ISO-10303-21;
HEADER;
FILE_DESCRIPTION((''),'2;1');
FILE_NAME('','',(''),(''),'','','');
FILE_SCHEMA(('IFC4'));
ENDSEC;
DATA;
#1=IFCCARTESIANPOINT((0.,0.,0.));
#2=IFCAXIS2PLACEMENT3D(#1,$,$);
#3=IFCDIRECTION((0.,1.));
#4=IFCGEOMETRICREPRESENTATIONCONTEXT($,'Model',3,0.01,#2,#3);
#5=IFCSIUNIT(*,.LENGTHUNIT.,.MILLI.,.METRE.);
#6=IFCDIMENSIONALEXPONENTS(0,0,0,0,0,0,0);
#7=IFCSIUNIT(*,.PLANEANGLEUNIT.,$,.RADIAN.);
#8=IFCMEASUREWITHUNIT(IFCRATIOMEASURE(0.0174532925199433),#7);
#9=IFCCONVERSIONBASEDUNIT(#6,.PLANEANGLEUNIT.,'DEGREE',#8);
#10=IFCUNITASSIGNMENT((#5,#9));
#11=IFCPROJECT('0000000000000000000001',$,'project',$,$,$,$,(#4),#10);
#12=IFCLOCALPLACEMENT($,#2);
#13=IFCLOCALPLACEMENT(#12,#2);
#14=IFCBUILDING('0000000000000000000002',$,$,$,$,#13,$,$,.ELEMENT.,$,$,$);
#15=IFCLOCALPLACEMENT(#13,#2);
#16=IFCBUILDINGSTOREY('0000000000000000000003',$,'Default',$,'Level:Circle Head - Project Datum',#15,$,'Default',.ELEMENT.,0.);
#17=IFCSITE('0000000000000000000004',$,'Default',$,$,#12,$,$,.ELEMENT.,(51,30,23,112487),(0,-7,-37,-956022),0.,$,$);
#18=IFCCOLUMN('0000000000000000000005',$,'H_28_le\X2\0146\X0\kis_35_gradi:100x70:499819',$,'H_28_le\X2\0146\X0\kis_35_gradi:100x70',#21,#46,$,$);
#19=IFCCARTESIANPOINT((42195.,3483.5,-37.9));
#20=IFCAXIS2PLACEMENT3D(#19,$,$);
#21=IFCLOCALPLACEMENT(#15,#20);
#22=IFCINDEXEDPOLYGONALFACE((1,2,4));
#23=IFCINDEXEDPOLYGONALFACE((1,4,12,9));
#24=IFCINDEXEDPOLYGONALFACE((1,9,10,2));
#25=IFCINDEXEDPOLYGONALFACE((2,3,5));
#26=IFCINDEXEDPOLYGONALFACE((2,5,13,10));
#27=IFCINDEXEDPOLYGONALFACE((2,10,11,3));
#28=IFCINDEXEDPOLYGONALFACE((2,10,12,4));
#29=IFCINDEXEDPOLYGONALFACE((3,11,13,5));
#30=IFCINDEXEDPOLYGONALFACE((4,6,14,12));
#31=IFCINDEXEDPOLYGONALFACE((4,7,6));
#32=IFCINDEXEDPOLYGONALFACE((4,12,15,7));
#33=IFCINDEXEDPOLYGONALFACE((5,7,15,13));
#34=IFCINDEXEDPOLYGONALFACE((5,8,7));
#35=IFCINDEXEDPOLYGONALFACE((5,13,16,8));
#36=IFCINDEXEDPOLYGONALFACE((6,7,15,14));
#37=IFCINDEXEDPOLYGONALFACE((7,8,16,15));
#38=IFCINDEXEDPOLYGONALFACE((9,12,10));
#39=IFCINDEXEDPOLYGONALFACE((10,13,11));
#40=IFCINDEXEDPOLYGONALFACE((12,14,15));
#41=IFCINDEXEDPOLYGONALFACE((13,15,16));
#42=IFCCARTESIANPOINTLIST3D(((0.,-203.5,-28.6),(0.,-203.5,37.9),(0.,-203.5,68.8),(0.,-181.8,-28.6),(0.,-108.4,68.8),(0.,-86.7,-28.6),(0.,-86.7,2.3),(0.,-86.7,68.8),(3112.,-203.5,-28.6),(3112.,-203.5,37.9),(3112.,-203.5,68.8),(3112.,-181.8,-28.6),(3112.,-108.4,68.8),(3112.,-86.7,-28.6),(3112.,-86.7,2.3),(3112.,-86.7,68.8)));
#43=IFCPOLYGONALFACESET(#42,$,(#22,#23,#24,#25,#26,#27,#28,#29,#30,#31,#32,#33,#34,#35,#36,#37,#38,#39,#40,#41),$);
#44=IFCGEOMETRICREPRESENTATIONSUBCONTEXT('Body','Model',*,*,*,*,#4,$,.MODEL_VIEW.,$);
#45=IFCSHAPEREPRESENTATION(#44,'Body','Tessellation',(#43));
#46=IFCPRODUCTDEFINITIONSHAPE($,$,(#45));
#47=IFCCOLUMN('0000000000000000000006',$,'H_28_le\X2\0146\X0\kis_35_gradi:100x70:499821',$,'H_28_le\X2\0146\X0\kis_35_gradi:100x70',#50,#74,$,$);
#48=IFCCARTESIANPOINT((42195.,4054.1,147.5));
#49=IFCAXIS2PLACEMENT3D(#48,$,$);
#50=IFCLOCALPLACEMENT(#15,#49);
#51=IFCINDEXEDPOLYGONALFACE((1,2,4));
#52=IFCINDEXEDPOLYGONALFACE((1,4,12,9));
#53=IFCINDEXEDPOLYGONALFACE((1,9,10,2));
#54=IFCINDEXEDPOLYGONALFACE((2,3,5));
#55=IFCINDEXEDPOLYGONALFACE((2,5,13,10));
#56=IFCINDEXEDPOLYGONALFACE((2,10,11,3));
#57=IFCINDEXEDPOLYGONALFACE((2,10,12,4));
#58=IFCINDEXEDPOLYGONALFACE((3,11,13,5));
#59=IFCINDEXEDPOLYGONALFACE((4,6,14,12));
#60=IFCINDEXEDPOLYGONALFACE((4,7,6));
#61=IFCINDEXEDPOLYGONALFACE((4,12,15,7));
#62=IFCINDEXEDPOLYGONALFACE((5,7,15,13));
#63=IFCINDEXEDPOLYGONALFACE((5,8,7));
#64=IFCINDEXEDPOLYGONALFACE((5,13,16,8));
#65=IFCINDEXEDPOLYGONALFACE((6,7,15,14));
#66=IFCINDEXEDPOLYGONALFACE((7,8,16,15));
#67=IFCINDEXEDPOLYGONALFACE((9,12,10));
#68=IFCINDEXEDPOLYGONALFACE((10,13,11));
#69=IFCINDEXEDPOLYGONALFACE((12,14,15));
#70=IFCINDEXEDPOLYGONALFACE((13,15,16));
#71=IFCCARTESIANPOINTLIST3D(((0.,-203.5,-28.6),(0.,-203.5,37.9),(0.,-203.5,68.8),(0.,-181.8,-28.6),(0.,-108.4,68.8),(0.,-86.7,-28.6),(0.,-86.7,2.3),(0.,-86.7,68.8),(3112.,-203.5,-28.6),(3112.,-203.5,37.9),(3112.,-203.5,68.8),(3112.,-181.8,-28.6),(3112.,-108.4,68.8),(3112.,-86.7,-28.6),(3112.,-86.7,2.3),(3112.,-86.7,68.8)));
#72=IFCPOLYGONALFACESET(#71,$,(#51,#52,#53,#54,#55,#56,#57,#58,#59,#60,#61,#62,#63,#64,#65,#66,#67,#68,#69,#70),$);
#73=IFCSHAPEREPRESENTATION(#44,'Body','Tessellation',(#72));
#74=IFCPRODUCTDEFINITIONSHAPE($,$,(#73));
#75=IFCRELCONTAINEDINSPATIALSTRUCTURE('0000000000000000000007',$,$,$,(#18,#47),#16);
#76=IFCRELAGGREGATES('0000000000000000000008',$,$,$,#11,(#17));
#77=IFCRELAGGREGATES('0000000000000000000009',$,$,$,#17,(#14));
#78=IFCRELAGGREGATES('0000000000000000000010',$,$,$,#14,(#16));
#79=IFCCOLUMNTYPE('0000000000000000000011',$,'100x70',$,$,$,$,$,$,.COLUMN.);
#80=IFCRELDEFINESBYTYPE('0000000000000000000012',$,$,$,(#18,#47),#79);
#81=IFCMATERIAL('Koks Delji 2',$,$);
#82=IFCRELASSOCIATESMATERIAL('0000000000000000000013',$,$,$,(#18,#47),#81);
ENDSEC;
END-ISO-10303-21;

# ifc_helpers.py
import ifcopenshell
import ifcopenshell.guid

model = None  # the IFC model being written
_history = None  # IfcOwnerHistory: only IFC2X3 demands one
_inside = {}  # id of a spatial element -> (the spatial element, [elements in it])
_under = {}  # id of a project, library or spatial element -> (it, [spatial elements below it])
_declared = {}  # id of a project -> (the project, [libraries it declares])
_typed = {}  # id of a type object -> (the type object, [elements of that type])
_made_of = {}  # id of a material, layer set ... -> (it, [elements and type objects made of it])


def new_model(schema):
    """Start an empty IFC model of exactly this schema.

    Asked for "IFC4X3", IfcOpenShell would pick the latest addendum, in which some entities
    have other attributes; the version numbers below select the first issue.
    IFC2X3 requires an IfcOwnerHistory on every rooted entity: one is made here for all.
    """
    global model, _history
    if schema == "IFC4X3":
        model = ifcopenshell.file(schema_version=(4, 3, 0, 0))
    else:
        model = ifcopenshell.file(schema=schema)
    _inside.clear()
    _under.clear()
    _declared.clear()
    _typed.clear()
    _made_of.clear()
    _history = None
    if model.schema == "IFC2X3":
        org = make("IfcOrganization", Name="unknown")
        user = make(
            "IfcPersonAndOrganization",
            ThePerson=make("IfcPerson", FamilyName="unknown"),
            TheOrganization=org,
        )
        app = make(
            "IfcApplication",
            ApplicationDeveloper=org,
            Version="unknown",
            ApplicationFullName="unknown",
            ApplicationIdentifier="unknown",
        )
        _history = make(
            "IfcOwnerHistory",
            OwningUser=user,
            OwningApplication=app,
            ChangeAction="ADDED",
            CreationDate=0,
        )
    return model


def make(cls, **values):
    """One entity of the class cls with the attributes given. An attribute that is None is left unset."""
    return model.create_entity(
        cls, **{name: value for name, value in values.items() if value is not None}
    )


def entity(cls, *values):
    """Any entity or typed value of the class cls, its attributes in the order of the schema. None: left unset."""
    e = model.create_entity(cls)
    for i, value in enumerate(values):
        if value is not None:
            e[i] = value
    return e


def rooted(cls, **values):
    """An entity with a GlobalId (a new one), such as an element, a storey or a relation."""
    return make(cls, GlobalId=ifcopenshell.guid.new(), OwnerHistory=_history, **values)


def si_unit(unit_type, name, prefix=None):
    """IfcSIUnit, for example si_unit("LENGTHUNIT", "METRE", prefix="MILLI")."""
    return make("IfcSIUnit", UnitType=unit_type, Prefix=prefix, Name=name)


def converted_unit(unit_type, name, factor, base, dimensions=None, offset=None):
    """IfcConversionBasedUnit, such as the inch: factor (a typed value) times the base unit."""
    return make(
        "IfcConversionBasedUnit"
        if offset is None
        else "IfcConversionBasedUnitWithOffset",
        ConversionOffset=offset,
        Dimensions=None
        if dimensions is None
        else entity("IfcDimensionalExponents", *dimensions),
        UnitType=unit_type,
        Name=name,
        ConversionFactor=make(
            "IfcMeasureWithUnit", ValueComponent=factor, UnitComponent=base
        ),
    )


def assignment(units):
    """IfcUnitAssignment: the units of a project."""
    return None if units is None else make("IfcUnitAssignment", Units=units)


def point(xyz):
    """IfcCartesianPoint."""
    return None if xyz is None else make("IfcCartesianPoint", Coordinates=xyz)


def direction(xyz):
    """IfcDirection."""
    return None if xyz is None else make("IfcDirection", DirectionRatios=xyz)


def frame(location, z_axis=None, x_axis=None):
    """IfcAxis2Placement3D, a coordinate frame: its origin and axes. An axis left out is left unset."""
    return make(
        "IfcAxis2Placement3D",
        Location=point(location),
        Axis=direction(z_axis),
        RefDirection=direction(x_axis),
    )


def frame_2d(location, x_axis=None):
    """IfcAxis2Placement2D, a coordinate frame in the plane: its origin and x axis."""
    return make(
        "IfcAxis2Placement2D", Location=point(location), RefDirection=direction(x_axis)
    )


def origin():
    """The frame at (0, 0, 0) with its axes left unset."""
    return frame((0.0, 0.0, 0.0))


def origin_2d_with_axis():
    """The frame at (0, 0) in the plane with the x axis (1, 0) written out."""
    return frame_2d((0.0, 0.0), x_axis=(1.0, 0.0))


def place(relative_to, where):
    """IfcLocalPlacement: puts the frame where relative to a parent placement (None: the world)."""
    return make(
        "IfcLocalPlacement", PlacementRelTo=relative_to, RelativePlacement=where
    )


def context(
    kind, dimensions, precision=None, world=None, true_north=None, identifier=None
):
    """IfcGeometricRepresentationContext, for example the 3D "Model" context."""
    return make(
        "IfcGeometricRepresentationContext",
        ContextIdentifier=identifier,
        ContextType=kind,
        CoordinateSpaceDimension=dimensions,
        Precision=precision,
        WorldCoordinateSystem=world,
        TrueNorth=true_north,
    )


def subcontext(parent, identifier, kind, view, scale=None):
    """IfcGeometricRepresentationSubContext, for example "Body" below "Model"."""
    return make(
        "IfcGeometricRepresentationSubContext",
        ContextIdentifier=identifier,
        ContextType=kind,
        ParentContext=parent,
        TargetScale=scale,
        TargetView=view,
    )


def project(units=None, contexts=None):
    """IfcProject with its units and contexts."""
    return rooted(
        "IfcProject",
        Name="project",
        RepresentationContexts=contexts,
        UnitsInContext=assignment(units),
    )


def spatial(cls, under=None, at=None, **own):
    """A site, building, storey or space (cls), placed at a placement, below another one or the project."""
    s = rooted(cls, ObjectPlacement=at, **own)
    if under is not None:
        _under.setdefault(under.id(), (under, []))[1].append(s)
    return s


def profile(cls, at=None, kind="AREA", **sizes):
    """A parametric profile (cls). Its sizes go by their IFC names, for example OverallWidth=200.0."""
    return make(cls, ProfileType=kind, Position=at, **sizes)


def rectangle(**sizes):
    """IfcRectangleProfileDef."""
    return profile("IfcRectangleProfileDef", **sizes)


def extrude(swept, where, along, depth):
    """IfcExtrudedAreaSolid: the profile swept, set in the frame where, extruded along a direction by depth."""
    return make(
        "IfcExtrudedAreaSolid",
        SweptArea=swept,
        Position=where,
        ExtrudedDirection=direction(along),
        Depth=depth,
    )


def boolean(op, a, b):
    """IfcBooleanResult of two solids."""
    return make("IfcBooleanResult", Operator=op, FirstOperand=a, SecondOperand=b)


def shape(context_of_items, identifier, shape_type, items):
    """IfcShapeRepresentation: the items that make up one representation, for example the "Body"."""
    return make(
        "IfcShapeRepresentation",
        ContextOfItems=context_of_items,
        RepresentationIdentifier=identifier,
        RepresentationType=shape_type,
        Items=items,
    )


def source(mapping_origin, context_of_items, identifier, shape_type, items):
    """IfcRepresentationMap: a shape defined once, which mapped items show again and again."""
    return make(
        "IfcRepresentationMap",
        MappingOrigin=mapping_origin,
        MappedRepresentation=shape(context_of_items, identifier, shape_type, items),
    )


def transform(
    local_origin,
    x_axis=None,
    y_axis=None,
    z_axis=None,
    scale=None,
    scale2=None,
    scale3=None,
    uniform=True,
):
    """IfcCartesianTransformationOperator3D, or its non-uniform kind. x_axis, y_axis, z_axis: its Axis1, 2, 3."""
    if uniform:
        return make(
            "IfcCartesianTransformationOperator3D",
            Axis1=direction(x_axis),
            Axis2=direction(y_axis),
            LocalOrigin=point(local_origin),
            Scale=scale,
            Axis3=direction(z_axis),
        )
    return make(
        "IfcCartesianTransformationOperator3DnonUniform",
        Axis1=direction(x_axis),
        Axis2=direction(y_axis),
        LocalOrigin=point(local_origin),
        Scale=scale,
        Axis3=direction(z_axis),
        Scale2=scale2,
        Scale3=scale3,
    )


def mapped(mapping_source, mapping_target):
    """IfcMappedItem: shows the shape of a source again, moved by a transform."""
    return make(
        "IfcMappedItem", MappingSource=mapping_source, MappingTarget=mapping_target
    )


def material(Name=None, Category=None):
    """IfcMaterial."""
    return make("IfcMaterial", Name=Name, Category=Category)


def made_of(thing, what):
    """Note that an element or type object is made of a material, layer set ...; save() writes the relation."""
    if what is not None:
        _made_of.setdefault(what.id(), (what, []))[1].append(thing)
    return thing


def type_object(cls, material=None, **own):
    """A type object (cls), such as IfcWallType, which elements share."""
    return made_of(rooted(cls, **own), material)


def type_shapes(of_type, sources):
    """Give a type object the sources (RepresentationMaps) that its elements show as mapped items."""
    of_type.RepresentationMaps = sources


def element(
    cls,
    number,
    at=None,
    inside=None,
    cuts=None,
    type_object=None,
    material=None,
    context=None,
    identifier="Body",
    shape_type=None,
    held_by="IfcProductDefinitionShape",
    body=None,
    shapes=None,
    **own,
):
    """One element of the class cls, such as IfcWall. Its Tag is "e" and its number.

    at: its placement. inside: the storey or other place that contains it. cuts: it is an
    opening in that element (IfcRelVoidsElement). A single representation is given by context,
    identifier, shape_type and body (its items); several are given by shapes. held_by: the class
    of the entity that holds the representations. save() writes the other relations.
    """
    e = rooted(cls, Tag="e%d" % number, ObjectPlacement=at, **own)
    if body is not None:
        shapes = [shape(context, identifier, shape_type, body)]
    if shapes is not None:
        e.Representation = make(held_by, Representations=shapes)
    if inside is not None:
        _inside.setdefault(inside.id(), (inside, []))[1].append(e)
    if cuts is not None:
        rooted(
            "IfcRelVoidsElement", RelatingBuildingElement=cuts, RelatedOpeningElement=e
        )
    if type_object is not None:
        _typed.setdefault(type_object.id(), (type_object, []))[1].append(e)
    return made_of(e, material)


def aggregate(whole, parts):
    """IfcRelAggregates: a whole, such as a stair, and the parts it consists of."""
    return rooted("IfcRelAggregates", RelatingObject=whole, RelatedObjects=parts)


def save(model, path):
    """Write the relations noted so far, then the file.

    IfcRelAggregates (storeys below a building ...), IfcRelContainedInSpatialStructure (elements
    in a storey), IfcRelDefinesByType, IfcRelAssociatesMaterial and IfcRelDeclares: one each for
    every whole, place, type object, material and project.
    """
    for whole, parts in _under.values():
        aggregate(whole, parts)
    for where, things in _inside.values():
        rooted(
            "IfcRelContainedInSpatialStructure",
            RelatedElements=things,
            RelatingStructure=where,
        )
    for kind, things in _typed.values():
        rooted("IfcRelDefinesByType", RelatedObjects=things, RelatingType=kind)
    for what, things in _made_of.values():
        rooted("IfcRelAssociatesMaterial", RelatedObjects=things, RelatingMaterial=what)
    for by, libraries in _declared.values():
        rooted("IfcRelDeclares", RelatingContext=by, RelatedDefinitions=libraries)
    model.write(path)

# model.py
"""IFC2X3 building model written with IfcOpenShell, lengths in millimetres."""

from ifc_helpers import new_model, entity, si_unit, converted_unit, direction, frame, frame_2d, origin, origin_2d_with_axis, place, context, subcontext, project, spatial, rectangle, extrude, boolean, source, transform, mapped, material, type_object, type_shapes, element, save


model = new_model("IFC2X3")

# Units and contexts
model_context = context("Model", 3, precision=0.01, world=origin(), true_north=direction((0.0, 1.0)))
body_context = subcontext(model_context, "Body", "Model", "MODEL_VIEW")
ifc_project = project(units=[si_unit("LENGTHUNIT", "METRE", prefix="MILLI"), converted_unit("PLANEANGLEUNIT", "DEGREE", entity("IfcRatioMeasure", 0.0174532925199433), si_unit("PLANEANGLEUNIT", "RADIAN"), dimensions=[0, 0, 0, 0, 0, 0, 0])], contexts=[model_context])

# Site, building, storey
site_placement = place(None, origin())
site = spatial("IfcSite", under=ifc_project, at=site_placement, Name="Default", CompositionType="ELEMENT", RefLatitude=(51, 30, 23, 112487), RefLongitude=(0, -7, -37, -956022), RefElevation=0.0)
building_placement = place(site_placement, origin())
building = spatial("IfcBuilding", under=site, at=building_placement, CompositionType="ELEMENT")
storey_placement = place(building_placement, origin())
storey = spatial("IfcBuildingStorey", under=building, at=storey_placement, Name="Default", ObjectType="Level:Circle Head - Project Datum", LongName="Default", CompositionType="ELEMENT", Elevation=0.0)

# Columns
ifc_material_1 = material(Name="Koks Delji 2")
column_type_1 = type_object("IfcColumnType", Name="100x70", PredefinedType="COLUMN")
shared_shape_1 = source(origin(), body_context, "Body", "CSG", [
    boolean("DIFFERENCE", extrude(rectangle(XDim=3112.0, YDim=116.7, at=origin_2d_with_axis()), frame((1556.0, -145.1, -28.6)), (0.0, 0.0, 1.0), 97.5), extrude(rectangle(XDim=70.0, YDim=100.0, at=frame_2d((0.0, 0.0), x_axis=(0.0, 1.0))), frame((0.0, -145.1, 20.1), z_axis=(-1.0, 0.0, 0.0), x_axis=(0.0, -0.951057, -0.309017)), (0.0, 0.0, -1.0), 3112.0)),
])
type_shapes(column_type_1, [shared_shape_1])
for number, where, name in (
    (1, (42195.0, 3483.5, -37.9), "H_28_leņkis_35_gradi:100x70:499819"),
    (2, (42195.0, 4054.1, 147.5), "H_28_leņkis_35_gradi:100x70:499821"),
):
    element("IfcColumn", number, at=place(storey_placement, frame(where)), inside=storey, type_object=column_type_1, material=ifc_material_1, Name=name, ObjectType="H_28_leņkis_35_gradi:100x70", context=body_context, shape_type="MappedRepresentation", body=[
        mapped(shared_shape_1, transform((0.0, 0.0, 0.0), scale=1.0)),
    ])

save(model, "model.ifc")
